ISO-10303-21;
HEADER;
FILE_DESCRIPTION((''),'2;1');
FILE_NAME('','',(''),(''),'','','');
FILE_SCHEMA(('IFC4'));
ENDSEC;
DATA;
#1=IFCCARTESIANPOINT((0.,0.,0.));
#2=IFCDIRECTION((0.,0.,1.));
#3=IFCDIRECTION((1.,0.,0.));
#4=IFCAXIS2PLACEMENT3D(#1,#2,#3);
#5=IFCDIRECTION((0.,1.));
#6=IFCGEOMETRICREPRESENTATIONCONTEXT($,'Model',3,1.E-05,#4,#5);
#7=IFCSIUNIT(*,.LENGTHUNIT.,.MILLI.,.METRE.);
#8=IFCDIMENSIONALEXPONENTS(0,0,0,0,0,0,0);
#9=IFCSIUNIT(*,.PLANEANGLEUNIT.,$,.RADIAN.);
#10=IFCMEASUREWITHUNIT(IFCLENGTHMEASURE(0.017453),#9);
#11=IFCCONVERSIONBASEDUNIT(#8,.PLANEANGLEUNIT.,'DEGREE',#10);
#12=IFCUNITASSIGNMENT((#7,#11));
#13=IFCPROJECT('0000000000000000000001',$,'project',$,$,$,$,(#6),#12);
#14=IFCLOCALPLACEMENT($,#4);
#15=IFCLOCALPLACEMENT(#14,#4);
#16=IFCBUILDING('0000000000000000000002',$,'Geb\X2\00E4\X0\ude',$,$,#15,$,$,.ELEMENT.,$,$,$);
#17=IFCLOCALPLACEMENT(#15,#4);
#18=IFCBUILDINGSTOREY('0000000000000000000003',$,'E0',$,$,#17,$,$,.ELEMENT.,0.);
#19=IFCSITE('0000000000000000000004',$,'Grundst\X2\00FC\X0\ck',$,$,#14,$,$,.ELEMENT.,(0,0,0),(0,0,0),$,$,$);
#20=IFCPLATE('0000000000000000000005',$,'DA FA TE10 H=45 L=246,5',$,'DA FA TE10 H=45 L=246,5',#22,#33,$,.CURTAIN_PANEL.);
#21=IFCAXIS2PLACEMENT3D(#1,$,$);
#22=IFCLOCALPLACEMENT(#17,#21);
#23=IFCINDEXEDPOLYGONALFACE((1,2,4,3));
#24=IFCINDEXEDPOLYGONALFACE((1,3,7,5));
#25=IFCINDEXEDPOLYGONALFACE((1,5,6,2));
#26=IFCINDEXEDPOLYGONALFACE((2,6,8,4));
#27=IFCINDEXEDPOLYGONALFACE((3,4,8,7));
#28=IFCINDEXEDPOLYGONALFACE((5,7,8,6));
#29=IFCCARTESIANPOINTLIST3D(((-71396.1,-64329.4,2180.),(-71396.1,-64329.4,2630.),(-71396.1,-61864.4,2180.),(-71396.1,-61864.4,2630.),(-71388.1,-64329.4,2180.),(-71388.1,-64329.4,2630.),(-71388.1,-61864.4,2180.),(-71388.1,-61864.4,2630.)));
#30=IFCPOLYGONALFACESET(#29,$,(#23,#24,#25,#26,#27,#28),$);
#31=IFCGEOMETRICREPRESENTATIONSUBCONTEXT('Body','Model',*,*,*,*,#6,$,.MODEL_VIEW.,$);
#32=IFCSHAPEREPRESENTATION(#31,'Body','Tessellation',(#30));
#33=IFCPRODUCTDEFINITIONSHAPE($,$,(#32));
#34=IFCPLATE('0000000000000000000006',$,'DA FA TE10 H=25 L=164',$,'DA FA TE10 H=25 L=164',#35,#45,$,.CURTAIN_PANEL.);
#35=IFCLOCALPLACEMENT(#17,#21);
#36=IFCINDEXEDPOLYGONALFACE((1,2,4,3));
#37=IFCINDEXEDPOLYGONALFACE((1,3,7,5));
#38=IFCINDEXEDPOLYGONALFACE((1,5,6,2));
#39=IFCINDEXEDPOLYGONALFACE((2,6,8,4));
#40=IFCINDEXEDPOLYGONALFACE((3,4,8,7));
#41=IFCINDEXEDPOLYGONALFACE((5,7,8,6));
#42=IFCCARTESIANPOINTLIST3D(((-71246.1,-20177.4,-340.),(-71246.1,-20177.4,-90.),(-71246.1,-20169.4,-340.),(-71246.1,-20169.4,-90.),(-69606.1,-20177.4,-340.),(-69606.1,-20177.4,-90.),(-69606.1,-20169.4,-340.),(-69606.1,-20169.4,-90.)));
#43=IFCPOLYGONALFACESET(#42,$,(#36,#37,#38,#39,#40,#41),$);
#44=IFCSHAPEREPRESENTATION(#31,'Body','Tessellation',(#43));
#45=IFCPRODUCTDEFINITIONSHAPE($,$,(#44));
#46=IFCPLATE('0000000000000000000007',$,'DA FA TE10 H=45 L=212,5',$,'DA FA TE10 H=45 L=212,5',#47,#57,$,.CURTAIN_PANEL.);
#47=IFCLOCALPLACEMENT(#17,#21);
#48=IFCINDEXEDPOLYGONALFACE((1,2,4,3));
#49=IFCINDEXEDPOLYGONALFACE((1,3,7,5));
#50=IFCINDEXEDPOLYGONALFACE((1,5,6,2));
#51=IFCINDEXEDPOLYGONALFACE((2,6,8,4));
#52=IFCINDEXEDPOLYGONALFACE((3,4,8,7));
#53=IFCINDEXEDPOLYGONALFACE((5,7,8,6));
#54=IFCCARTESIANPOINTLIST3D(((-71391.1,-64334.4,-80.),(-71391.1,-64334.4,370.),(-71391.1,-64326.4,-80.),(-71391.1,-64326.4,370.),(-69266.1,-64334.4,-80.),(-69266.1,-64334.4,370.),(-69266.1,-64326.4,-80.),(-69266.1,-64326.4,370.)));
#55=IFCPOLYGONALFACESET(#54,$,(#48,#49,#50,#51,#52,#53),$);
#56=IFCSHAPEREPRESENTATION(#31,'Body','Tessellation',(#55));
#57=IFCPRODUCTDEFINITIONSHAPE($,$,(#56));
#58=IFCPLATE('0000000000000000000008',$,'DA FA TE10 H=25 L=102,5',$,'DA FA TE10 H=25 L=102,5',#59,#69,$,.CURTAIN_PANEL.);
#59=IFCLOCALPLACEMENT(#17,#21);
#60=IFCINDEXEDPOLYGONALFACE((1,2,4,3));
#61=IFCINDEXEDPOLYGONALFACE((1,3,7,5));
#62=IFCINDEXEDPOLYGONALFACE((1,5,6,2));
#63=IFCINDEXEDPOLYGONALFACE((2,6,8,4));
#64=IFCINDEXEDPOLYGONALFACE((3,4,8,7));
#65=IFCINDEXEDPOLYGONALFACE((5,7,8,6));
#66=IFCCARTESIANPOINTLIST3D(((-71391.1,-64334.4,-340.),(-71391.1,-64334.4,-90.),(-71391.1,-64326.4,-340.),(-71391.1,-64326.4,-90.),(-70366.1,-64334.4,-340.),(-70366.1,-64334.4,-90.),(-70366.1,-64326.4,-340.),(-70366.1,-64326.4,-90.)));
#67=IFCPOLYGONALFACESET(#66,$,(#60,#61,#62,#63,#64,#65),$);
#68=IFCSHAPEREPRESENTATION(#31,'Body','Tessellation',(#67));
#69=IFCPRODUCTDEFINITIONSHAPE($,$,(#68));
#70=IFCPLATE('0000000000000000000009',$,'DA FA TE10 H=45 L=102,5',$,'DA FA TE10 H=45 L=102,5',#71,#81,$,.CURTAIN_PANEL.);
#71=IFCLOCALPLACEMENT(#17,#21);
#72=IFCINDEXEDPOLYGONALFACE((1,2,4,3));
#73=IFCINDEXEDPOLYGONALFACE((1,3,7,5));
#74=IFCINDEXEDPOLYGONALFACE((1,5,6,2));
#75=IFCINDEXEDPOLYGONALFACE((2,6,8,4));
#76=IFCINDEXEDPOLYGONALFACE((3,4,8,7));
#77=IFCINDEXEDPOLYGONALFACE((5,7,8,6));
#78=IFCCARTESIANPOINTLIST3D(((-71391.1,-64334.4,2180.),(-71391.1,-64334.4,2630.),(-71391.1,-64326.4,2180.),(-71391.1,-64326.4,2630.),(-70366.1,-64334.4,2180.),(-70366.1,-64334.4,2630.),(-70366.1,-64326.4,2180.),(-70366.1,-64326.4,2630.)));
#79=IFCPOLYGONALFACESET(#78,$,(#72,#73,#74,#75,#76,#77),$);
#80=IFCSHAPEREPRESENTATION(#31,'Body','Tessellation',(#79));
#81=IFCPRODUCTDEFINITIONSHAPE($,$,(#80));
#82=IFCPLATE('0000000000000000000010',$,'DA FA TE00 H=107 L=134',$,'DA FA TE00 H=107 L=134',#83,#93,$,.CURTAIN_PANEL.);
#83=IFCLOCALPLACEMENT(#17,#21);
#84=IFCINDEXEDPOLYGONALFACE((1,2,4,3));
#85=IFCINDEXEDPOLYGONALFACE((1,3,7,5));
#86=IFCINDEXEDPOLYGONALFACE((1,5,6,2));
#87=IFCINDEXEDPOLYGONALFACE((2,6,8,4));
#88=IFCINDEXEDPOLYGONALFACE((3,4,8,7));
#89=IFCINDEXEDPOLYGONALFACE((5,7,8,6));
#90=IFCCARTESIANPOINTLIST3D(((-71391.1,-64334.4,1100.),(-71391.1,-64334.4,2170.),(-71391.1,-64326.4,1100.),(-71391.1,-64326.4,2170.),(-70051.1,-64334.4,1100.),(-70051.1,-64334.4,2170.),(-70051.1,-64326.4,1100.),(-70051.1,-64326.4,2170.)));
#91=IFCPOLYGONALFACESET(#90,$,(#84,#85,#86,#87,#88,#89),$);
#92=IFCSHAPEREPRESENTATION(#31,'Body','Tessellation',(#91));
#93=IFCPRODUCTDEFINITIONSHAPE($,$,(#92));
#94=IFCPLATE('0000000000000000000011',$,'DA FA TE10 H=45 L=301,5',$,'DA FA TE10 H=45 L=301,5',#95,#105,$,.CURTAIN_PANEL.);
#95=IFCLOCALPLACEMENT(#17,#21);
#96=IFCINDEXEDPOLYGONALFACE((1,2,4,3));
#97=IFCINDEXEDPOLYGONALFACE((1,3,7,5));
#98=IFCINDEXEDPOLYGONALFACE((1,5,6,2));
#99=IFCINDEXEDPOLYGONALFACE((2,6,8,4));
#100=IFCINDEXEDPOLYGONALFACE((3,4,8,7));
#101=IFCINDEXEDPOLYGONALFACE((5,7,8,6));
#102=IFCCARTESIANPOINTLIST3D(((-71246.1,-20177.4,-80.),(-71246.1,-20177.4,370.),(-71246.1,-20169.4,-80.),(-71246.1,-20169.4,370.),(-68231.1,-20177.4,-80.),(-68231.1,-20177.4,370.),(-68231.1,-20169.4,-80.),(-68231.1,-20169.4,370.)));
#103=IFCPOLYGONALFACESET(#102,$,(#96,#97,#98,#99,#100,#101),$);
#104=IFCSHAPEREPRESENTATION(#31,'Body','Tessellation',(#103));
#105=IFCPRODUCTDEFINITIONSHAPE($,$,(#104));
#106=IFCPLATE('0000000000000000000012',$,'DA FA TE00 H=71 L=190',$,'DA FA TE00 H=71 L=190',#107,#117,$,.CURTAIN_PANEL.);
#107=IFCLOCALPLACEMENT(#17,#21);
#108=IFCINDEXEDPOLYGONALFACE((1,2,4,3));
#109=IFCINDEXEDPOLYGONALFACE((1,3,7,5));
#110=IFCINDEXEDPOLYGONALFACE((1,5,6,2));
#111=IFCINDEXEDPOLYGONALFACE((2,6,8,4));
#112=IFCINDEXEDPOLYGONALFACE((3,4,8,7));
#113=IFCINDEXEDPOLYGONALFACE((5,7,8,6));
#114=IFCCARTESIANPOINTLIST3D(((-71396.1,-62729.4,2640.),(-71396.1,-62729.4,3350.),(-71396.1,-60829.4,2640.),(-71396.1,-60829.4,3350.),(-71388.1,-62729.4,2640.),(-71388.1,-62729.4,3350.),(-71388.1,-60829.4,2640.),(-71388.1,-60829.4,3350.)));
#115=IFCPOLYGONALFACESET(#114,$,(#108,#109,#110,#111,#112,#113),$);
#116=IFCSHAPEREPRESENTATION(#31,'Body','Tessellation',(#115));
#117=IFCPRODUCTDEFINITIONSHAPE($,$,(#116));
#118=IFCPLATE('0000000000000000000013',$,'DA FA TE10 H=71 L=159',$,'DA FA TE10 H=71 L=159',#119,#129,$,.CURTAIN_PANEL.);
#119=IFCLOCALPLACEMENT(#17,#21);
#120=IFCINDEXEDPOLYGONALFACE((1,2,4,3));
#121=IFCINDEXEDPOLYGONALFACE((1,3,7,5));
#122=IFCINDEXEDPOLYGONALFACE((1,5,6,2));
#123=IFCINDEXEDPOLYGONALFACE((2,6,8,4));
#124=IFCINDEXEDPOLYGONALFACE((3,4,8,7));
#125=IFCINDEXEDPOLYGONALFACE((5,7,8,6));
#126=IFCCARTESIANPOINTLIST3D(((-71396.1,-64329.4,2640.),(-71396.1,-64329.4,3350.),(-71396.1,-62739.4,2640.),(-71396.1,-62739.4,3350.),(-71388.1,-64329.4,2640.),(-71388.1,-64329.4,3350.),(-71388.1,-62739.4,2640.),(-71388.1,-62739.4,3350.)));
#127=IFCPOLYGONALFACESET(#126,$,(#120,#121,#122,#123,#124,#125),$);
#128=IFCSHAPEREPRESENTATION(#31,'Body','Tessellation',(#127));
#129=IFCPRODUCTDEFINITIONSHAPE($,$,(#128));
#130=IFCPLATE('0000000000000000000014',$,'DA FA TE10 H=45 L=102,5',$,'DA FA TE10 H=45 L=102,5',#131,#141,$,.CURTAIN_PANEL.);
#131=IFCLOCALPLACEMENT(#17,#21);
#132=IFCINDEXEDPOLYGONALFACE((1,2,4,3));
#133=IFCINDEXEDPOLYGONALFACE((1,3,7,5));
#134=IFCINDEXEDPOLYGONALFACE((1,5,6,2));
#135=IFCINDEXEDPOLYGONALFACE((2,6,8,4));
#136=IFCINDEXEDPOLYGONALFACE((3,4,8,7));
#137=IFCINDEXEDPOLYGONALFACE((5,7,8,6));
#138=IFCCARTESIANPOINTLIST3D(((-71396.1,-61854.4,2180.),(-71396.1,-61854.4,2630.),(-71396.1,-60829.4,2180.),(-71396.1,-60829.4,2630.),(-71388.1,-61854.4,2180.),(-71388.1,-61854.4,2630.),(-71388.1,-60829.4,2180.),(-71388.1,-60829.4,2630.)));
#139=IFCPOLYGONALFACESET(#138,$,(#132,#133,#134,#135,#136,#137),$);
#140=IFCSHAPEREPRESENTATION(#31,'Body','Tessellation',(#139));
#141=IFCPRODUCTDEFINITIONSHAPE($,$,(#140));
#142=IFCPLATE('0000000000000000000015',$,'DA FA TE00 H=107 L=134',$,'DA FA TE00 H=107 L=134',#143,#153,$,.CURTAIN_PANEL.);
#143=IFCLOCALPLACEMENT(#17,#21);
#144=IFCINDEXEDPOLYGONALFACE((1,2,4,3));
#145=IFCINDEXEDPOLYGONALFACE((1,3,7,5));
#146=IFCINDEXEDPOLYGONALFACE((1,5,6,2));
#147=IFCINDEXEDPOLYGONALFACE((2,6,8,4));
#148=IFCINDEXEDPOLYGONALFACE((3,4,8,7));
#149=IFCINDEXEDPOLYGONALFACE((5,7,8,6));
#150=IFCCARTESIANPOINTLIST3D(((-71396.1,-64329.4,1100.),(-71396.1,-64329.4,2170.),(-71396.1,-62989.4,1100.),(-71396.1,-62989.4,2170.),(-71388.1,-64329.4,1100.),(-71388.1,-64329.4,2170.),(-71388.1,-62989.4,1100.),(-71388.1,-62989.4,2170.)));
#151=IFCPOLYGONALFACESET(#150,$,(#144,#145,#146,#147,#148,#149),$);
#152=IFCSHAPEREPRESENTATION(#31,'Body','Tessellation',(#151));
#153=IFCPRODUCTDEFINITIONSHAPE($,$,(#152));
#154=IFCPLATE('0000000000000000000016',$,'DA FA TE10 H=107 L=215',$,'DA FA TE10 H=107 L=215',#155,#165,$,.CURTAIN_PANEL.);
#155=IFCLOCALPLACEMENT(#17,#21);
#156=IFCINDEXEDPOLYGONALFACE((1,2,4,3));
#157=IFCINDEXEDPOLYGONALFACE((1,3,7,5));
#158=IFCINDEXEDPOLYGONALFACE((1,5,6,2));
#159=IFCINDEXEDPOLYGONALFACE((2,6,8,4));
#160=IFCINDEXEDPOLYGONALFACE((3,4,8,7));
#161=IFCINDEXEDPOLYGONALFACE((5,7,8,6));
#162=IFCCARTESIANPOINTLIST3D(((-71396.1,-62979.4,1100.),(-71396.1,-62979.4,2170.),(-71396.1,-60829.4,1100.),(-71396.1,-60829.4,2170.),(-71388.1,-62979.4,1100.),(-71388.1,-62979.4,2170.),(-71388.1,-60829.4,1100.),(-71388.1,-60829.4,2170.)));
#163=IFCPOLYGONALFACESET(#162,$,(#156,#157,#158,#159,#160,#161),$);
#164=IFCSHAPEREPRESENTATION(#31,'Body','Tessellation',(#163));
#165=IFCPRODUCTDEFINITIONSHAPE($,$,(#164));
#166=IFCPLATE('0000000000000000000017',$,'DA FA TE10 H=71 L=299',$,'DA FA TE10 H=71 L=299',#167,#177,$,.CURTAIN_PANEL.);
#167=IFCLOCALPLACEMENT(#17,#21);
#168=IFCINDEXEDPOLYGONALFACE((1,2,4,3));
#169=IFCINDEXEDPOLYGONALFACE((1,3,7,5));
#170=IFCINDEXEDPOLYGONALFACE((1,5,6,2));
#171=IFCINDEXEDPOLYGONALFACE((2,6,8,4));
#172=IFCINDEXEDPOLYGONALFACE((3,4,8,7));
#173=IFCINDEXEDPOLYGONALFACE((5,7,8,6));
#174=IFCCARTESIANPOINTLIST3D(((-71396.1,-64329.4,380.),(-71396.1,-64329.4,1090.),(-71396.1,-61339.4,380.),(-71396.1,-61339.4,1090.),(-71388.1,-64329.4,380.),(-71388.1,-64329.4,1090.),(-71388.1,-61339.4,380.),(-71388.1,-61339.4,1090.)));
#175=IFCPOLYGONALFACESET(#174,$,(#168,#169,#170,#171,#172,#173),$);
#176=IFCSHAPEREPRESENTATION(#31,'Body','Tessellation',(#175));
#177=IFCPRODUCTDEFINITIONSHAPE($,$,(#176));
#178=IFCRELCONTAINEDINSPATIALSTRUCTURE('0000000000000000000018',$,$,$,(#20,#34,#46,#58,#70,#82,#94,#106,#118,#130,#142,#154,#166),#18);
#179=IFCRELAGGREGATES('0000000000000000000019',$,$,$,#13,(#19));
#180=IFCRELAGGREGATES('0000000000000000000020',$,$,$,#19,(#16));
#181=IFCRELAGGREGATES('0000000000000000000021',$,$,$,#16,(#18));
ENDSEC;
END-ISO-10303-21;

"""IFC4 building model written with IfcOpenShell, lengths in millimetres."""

from ifc_helpers import new_model, entity, si_unit, converted_unit, direction, frame, origin_with_axes, place, context, subcontext, project, spatial, line, indexed_curve, outline, extrude, source, transform, mapped, element, save


model = new_model("IFC4")

# Units and contexts
model_context = context("Model", 3, precision=1e-05, world=origin_with_axes(), true_north=direction((0.0, 1.0)))
body_context = subcontext(model_context, "Body", "Model", "MODEL_VIEW")
ifc_project = project(units=[si_unit("LENGTHUNIT", "METRE", prefix="MILLI"), converted_unit("PLANEANGLEUNIT", "DEGREE", entity("IfcLengthMeasure", 0.017453), si_unit("PLANEANGLEUNIT", "RADIAN"), dimensions=[0, 0, 0, 0, 0, 0, 0])], contexts=[model_context])

# Site, building, storey
site_placement = place(None, origin_with_axes())
site = spatial("IfcSite", under=ifc_project, at=site_placement, Name="Grundstück", CompositionType="ELEMENT", RefLatitude=(0, 0, 0), RefLongitude=(0, 0, 0))
building_placement = place(site_placement, origin_with_axes())
building = spatial("IfcBuilding", under=site, at=building_placement, Name="Gebäude", CompositionType="ELEMENT")
storey_placement = place(building_placement, origin_with_axes())
storey = spatial("IfcBuildingStorey", under=building, at=storey_placement, Name="E0", CompositionType="ELEMENT", Elevation=0.0)

# Plates
shared_shape_1 = source(origin_with_axes(), body_context, "Body", "SweptSolid", [
    extrude(outline(indexed_curve([(-1232.5, 0.0), (1232.5, 0.0), (1232.5, 8.0), (-1232.5, 8.0)], segments=[line(1, 2), line(2, 3), line(3, 4), line(4, 1)])), frame((0.0, 0.0, 450.0), z_axis=(0.0, 0.0, 1.0), x_axis=(1.0, 0.0, 0.0)), (0.0, 0.0, -1.0), 450.0),
])
plate_1_placement = place(storey_placement, frame((-71396.1, -63096.9, 2180.0), z_axis=(0.0, 0.0, 1.0), x_axis=(0.0, -1.0, 0.0)))
element("IfcPlate", 1, at=plate_1_placement, inside=storey, Name="DA FA TE10 H=45 L=246,5", ObjectType="DA FA TE10 H=45 L=246,5", PredefinedType="CURTAIN_PANEL", context=body_context, shape_type="MappedRepresentation", body=[
    mapped(shared_shape_1, transform((0.0, 0.0, 0.0), x_axis=(1.0, 0.0, 0.0), y_axis=(0.0, 1.0, 0.0), z_axis=(0.0, 0.0, 1.0), scale=1.0)),
])
shared_shape_2 = source(origin_with_axes(), body_context, "Body", "SweptSolid", [
    extrude(outline(indexed_curve([(-820.0, 0.0), (820.0, 0.0), (820.0, 8.0), (-820.0, 8.0)], segments=[line(1, 2), line(2, 3), line(3, 4), line(4, 1)])), frame((0.0, 0.0, 250.0), z_axis=(0.0, 0.0, 1.0), x_axis=(1.0, 0.0, 0.0)), (0.0, 0.0, -1.0), 250.0),
])
plate_2_placement = place(storey_placement, frame((-70426.1, -20169.4, -340.0), z_axis=(0.0, 0.0, 1.0), x_axis=(-1.0, 0.0, 0.0)))
element("IfcPlate", 2, at=plate_2_placement, inside=storey, Name="DA FA TE10 H=25 L=164", ObjectType="DA FA TE10 H=25 L=164", PredefinedType="CURTAIN_PANEL", context=body_context, shape_type="MappedRepresentation", body=[
    mapped(shared_shape_2, transform((0.0, 0.0, 0.0), x_axis=(1.0, 0.0, 0.0), y_axis=(0.0, 1.0, 0.0), z_axis=(0.0, 0.0, 1.0), scale=1.0)),
])
shared_shape_3 = source(origin_with_axes(), body_context, "Body", "SweptSolid", [
    extrude(outline(indexed_curve([(-1062.5, 0.0), (1062.5, 0.0), (1062.5, 8.0), (-1062.5, 8.0)], segments=[line(1, 2), line(2, 3), line(3, 4), line(4, 1)])), frame((0.0, 0.0, 450.0), z_axis=(0.0, 0.0, 1.0), x_axis=(1.0, 0.0, 0.0)), (0.0, 0.0, -1.0), 450.0),
])
plate_3_placement = place(storey_placement, frame((-70328.6, -64334.4, -80.0), z_axis=(0.0, 0.0, 1.0), x_axis=(1.0, 0.0, 0.0)))
element("IfcPlate", 3, at=plate_3_placement, inside=storey, Name="DA FA TE10 H=45 L=212,5", ObjectType="DA FA TE10 H=45 L=212,5", PredefinedType="CURTAIN_PANEL", context=body_context, shape_type="MappedRepresentation", body=[
    mapped(shared_shape_3, transform((0.0, 0.0, 0.0), x_axis=(1.0, 0.0, 0.0), y_axis=(0.0, 1.0, 0.0), z_axis=(0.0, 0.0, 1.0), scale=1.0)),
])
shared_shape_4 = source(origin_with_axes(), body_context, "Body", "SweptSolid", [
    extrude(outline(indexed_curve([(-512.5, 0.0), (512.5, 0.0), (512.5, 8.0), (-512.5, 8.0)], segments=[line(1, 2), line(2, 3), line(3, 4), line(4, 1)])), frame((0.0, 0.0, 250.0), z_axis=(0.0, 0.0, 1.0), x_axis=(1.0, 0.0, 0.0)), (0.0, 0.0, -1.0), 250.0),
])
plate_4_placement = place(storey_placement, frame((-70878.6, -64334.4, -340.0), z_axis=(0.0, 0.0, 1.0), x_axis=(1.0, 0.0, 0.0)))
element("IfcPlate", 4, at=plate_4_placement, inside=storey, Name="DA FA TE10 H=25 L=102,5", ObjectType="DA FA TE10 H=25 L=102,5", PredefinedType="CURTAIN_PANEL", context=body_context, shape_type="MappedRepresentation", body=[
    mapped(shared_shape_4, transform((0.0, 0.0, 0.0), x_axis=(1.0, 0.0, 0.0), y_axis=(0.0, 1.0, 0.0), z_axis=(0.0, 0.0, 1.0), scale=1.0)),
])
shared_shape_5 = source(origin_with_axes(), body_context, "Body", "SweptSolid", [
    extrude(outline(indexed_curve([(-512.5, 0.0), (512.5, 0.0), (512.5, 8.0), (-512.5, 8.0)], segments=[line(1, 2), line(2, 3), line(3, 4), line(4, 1)])), frame((0.0, 0.0, 450.0), z_axis=(0.0, 0.0, 1.0), x_axis=(1.0, 0.0, 0.0)), (0.0, 0.0, -1.0), 450.0),
])
plate_5_placement = place(storey_placement, frame((-70878.6, -64334.4, 2180.0), z_axis=(0.0, 0.0, 1.0), x_axis=(1.0, 0.0, 0.0)))
element("IfcPlate", 5, at=plate_5_placement, inside=storey, Name="DA FA TE10 H=45 L=102,5", ObjectType="DA FA TE10 H=45 L=102,5", PredefinedType="CURTAIN_PANEL", context=body_context, shape_type="MappedRepresentation", body=[
    mapped(shared_shape_5, transform((0.0, 0.0, 0.0), x_axis=(1.0, 0.0, 0.0), y_axis=(0.0, 1.0, 0.0), z_axis=(0.0, 0.0, 1.0), scale=1.0)),
])
shared_shape_6 = source(origin_with_axes(), body_context, "Body", "SweptSolid", [
    extrude(outline(indexed_curve([(-670.0, 0.0), (670.0, 0.0), (670.0, 8.0), (-670.0, 8.0)], segments=[line(1, 2), line(2, 3), line(3, 4), line(4, 1)])), frame((0.0, 0.0, 1070.0), z_axis=(0.0, 0.0, 1.0), x_axis=(1.0, 0.0, 0.0)), (0.0, 0.0, -1.0), 1070.0),
])
plate_6_placement = place(storey_placement, frame((-70721.1, -64334.4, 1100.0), z_axis=(0.0, 0.0, 1.0), x_axis=(1.0, 0.0, 0.0)))
element("IfcPlate", 6, at=plate_6_placement, inside=storey, Name="DA FA TE00 H=107 L=134", ObjectType="DA FA TE00 H=107 L=134", PredefinedType="CURTAIN_PANEL", context=body_context, shape_type="MappedRepresentation", body=[
    mapped(shared_shape_6, transform((0.0, 0.0, 0.0), x_axis=(1.0, 0.0, 0.0), y_axis=(0.0, 1.0, 0.0), z_axis=(0.0, 0.0, 1.0), scale=1.0)),
])
plate_7_placement = place(storey_placement, frame((-69738.6, -20169.4, -80.0), z_axis=(0.0, 0.0, 1.0), x_axis=(-1.0, 0.0, 0.0)))
element("IfcPlate", 7, at=plate_7_placement, inside=storey, Name="DA FA TE10 H=45 L=301,5", ObjectType="DA FA TE10 H=45 L=301,5", PredefinedType="CURTAIN_PANEL", context=body_context, shape_type="SweptSolid", body=[
    extrude(outline(indexed_curve([(-1507.5, 0.0), (1507.5, 0.0), (1507.5, 8.0), (-1507.5, 8.0)], segments=[line(1, 2), line(2, 3), line(3, 4), line(4, 1)])), frame((0.0, 0.0, 450.0), z_axis=(0.0, 0.0, 1.0), x_axis=(1.0, 0.0, 0.0)), (0.0, 0.0, -1.0), 450.0),
])
plate_8_placement = place(storey_placement, frame((-71396.1, -61779.4, 2640.0), z_axis=(0.0, 0.0, 1.0), x_axis=(0.0, -1.0, 0.0)))
element("IfcPlate", 8, at=plate_8_placement, inside=storey, Name="DA FA TE00 H=71 L=190", ObjectType="DA FA TE00 H=71 L=190", PredefinedType="CURTAIN_PANEL", context=body_context, shape_type="SweptSolid", body=[
    extrude(outline(indexed_curve([(-950.0, 0.0), (950.0, 0.0), (950.0, 8.0), (-950.0, 8.0)], segments=[line(1, 2), line(2, 3), line(3, 4), line(4, 1)])), frame((0.0, 0.0, 710.0), z_axis=(0.0, 0.0, 1.0), x_axis=(1.0, 0.0, 0.0)), (0.0, 0.0, -1.0), 710.0),
])
plate_9_placement = place(storey_placement, frame((-71396.1, -63534.4, 2640.0), z_axis=(0.0, 0.0, 1.0), x_axis=(0.0, -1.0, 0.0)))
element("IfcPlate", 9, at=plate_9_placement, inside=storey, Name="DA FA TE10 H=71 L=159", ObjectType="DA FA TE10 H=71 L=159", PredefinedType="CURTAIN_PANEL", context=body_context, shape_type="SweptSolid", body=[
    extrude(outline(indexed_curve([(-795.0, 0.0), (795.0, 0.0), (795.0, 8.0), (-795.0, 8.0)], segments=[line(1, 2), line(2, 3), line(3, 4), line(4, 1)])), frame((0.0, 0.0, 710.0), z_axis=(0.0, 0.0, 1.0), x_axis=(1.0, 0.0, 0.0)), (0.0, 0.0, -1.0), 710.0),
])
plate_10_placement = place(storey_placement, frame((-71396.1, -61341.9, 2180.0), z_axis=(0.0, 0.0, 1.0), x_axis=(0.0, -1.0, 0.0)))
element("IfcPlate", 10, at=plate_10_placement, inside=storey, Name="DA FA TE10 H=45 L=102,5", ObjectType="DA FA TE10 H=45 L=102,5", PredefinedType="CURTAIN_PANEL", context=body_context, shape_type="SweptSolid", body=[
    extrude(outline(indexed_curve([(-512.5, 0.0), (512.5, 0.0), (512.5, 8.0), (-512.5, 8.0)], segments=[line(1, 2), line(2, 3), line(3, 4), line(4, 1)])), frame((0.0, 0.0, 450.0), z_axis=(0.0, 0.0, 1.0), x_axis=(1.0, 0.0, 0.0)), (0.0, 0.0, -1.0), 450.0),
])
plate_11_placement = place(storey_placement, frame((-71396.1, -63659.4, 1100.0), z_axis=(0.0, 0.0, 1.0), x_axis=(0.0, -1.0, 0.0)))
element("IfcPlate", 11, at=plate_11_placement, inside=storey, Name="DA FA TE00 H=107 L=134", ObjectType="DA FA TE00 H=107 L=134", PredefinedType="CURTAIN_PANEL", context=body_context, shape_type="SweptSolid", body=[
    extrude(outline(indexed_curve([(-670.0, 0.0), (670.0, 0.0), (670.0, 8.0), (-670.0, 8.0)], segments=[line(1, 2), line(2, 3), line(3, 4), line(4, 1)])), frame((0.0, 0.0, 1070.0), z_axis=(0.0, 0.0, 1.0), x_axis=(1.0, 0.0, 0.0)), (0.0, 0.0, -1.0), 1070.0),
])
plate_12_placement = place(storey_placement, frame((-71396.1, -61904.4, 1100.0), z_axis=(0.0, 0.0, 1.0), x_axis=(0.0, -1.0, 0.0)))
element("IfcPlate", 12, at=plate_12_placement, inside=storey, Name="DA FA TE10 H=107 L=215", ObjectType="DA FA TE10 H=107 L=215", PredefinedType="CURTAIN_PANEL", context=body_context, shape_type="SweptSolid", body=[
    extrude(outline(indexed_curve([(-1075.0, 0.0), (1075.0, 0.0), (1075.0, 8.0), (-1075.0, 8.0)], segments=[line(1, 2), line(2, 3), line(3, 4), line(4, 1)])), frame((0.0, 0.0, 1070.0), z_axis=(0.0, 0.0, 1.0), x_axis=(1.0, 0.0, 0.0)), (0.0, 0.0, -1.0), 1070.0),
])
plate_13_placement = place(storey_placement, frame((-71396.1, -62834.4, 380.0), z_axis=(0.0, 0.0, 1.0), x_axis=(0.0, -1.0, 0.0)))
element("IfcPlate", 13, at=plate_13_placement, inside=storey, Name="DA FA TE10 H=71 L=299", ObjectType="DA FA TE10 H=71 L=299", PredefinedType="CURTAIN_PANEL", context=body_context, shape_type="SweptSolid", body=[
    extrude(outline(indexed_curve([(-1495.0, 0.0), (1495.0, 0.0), (1495.0, 8.0), (-1495.0, 8.0)], segments=[line(1, 2), line(2, 3), line(3, 4), line(4, 1)])), frame((0.0, 0.0, 710.0), z_axis=(0.0, 0.0, 1.0), x_axis=(1.0, 0.0, 0.0)), (0.0, 0.0, -1.0), 710.0),
])

save(model, "model.ifc")
